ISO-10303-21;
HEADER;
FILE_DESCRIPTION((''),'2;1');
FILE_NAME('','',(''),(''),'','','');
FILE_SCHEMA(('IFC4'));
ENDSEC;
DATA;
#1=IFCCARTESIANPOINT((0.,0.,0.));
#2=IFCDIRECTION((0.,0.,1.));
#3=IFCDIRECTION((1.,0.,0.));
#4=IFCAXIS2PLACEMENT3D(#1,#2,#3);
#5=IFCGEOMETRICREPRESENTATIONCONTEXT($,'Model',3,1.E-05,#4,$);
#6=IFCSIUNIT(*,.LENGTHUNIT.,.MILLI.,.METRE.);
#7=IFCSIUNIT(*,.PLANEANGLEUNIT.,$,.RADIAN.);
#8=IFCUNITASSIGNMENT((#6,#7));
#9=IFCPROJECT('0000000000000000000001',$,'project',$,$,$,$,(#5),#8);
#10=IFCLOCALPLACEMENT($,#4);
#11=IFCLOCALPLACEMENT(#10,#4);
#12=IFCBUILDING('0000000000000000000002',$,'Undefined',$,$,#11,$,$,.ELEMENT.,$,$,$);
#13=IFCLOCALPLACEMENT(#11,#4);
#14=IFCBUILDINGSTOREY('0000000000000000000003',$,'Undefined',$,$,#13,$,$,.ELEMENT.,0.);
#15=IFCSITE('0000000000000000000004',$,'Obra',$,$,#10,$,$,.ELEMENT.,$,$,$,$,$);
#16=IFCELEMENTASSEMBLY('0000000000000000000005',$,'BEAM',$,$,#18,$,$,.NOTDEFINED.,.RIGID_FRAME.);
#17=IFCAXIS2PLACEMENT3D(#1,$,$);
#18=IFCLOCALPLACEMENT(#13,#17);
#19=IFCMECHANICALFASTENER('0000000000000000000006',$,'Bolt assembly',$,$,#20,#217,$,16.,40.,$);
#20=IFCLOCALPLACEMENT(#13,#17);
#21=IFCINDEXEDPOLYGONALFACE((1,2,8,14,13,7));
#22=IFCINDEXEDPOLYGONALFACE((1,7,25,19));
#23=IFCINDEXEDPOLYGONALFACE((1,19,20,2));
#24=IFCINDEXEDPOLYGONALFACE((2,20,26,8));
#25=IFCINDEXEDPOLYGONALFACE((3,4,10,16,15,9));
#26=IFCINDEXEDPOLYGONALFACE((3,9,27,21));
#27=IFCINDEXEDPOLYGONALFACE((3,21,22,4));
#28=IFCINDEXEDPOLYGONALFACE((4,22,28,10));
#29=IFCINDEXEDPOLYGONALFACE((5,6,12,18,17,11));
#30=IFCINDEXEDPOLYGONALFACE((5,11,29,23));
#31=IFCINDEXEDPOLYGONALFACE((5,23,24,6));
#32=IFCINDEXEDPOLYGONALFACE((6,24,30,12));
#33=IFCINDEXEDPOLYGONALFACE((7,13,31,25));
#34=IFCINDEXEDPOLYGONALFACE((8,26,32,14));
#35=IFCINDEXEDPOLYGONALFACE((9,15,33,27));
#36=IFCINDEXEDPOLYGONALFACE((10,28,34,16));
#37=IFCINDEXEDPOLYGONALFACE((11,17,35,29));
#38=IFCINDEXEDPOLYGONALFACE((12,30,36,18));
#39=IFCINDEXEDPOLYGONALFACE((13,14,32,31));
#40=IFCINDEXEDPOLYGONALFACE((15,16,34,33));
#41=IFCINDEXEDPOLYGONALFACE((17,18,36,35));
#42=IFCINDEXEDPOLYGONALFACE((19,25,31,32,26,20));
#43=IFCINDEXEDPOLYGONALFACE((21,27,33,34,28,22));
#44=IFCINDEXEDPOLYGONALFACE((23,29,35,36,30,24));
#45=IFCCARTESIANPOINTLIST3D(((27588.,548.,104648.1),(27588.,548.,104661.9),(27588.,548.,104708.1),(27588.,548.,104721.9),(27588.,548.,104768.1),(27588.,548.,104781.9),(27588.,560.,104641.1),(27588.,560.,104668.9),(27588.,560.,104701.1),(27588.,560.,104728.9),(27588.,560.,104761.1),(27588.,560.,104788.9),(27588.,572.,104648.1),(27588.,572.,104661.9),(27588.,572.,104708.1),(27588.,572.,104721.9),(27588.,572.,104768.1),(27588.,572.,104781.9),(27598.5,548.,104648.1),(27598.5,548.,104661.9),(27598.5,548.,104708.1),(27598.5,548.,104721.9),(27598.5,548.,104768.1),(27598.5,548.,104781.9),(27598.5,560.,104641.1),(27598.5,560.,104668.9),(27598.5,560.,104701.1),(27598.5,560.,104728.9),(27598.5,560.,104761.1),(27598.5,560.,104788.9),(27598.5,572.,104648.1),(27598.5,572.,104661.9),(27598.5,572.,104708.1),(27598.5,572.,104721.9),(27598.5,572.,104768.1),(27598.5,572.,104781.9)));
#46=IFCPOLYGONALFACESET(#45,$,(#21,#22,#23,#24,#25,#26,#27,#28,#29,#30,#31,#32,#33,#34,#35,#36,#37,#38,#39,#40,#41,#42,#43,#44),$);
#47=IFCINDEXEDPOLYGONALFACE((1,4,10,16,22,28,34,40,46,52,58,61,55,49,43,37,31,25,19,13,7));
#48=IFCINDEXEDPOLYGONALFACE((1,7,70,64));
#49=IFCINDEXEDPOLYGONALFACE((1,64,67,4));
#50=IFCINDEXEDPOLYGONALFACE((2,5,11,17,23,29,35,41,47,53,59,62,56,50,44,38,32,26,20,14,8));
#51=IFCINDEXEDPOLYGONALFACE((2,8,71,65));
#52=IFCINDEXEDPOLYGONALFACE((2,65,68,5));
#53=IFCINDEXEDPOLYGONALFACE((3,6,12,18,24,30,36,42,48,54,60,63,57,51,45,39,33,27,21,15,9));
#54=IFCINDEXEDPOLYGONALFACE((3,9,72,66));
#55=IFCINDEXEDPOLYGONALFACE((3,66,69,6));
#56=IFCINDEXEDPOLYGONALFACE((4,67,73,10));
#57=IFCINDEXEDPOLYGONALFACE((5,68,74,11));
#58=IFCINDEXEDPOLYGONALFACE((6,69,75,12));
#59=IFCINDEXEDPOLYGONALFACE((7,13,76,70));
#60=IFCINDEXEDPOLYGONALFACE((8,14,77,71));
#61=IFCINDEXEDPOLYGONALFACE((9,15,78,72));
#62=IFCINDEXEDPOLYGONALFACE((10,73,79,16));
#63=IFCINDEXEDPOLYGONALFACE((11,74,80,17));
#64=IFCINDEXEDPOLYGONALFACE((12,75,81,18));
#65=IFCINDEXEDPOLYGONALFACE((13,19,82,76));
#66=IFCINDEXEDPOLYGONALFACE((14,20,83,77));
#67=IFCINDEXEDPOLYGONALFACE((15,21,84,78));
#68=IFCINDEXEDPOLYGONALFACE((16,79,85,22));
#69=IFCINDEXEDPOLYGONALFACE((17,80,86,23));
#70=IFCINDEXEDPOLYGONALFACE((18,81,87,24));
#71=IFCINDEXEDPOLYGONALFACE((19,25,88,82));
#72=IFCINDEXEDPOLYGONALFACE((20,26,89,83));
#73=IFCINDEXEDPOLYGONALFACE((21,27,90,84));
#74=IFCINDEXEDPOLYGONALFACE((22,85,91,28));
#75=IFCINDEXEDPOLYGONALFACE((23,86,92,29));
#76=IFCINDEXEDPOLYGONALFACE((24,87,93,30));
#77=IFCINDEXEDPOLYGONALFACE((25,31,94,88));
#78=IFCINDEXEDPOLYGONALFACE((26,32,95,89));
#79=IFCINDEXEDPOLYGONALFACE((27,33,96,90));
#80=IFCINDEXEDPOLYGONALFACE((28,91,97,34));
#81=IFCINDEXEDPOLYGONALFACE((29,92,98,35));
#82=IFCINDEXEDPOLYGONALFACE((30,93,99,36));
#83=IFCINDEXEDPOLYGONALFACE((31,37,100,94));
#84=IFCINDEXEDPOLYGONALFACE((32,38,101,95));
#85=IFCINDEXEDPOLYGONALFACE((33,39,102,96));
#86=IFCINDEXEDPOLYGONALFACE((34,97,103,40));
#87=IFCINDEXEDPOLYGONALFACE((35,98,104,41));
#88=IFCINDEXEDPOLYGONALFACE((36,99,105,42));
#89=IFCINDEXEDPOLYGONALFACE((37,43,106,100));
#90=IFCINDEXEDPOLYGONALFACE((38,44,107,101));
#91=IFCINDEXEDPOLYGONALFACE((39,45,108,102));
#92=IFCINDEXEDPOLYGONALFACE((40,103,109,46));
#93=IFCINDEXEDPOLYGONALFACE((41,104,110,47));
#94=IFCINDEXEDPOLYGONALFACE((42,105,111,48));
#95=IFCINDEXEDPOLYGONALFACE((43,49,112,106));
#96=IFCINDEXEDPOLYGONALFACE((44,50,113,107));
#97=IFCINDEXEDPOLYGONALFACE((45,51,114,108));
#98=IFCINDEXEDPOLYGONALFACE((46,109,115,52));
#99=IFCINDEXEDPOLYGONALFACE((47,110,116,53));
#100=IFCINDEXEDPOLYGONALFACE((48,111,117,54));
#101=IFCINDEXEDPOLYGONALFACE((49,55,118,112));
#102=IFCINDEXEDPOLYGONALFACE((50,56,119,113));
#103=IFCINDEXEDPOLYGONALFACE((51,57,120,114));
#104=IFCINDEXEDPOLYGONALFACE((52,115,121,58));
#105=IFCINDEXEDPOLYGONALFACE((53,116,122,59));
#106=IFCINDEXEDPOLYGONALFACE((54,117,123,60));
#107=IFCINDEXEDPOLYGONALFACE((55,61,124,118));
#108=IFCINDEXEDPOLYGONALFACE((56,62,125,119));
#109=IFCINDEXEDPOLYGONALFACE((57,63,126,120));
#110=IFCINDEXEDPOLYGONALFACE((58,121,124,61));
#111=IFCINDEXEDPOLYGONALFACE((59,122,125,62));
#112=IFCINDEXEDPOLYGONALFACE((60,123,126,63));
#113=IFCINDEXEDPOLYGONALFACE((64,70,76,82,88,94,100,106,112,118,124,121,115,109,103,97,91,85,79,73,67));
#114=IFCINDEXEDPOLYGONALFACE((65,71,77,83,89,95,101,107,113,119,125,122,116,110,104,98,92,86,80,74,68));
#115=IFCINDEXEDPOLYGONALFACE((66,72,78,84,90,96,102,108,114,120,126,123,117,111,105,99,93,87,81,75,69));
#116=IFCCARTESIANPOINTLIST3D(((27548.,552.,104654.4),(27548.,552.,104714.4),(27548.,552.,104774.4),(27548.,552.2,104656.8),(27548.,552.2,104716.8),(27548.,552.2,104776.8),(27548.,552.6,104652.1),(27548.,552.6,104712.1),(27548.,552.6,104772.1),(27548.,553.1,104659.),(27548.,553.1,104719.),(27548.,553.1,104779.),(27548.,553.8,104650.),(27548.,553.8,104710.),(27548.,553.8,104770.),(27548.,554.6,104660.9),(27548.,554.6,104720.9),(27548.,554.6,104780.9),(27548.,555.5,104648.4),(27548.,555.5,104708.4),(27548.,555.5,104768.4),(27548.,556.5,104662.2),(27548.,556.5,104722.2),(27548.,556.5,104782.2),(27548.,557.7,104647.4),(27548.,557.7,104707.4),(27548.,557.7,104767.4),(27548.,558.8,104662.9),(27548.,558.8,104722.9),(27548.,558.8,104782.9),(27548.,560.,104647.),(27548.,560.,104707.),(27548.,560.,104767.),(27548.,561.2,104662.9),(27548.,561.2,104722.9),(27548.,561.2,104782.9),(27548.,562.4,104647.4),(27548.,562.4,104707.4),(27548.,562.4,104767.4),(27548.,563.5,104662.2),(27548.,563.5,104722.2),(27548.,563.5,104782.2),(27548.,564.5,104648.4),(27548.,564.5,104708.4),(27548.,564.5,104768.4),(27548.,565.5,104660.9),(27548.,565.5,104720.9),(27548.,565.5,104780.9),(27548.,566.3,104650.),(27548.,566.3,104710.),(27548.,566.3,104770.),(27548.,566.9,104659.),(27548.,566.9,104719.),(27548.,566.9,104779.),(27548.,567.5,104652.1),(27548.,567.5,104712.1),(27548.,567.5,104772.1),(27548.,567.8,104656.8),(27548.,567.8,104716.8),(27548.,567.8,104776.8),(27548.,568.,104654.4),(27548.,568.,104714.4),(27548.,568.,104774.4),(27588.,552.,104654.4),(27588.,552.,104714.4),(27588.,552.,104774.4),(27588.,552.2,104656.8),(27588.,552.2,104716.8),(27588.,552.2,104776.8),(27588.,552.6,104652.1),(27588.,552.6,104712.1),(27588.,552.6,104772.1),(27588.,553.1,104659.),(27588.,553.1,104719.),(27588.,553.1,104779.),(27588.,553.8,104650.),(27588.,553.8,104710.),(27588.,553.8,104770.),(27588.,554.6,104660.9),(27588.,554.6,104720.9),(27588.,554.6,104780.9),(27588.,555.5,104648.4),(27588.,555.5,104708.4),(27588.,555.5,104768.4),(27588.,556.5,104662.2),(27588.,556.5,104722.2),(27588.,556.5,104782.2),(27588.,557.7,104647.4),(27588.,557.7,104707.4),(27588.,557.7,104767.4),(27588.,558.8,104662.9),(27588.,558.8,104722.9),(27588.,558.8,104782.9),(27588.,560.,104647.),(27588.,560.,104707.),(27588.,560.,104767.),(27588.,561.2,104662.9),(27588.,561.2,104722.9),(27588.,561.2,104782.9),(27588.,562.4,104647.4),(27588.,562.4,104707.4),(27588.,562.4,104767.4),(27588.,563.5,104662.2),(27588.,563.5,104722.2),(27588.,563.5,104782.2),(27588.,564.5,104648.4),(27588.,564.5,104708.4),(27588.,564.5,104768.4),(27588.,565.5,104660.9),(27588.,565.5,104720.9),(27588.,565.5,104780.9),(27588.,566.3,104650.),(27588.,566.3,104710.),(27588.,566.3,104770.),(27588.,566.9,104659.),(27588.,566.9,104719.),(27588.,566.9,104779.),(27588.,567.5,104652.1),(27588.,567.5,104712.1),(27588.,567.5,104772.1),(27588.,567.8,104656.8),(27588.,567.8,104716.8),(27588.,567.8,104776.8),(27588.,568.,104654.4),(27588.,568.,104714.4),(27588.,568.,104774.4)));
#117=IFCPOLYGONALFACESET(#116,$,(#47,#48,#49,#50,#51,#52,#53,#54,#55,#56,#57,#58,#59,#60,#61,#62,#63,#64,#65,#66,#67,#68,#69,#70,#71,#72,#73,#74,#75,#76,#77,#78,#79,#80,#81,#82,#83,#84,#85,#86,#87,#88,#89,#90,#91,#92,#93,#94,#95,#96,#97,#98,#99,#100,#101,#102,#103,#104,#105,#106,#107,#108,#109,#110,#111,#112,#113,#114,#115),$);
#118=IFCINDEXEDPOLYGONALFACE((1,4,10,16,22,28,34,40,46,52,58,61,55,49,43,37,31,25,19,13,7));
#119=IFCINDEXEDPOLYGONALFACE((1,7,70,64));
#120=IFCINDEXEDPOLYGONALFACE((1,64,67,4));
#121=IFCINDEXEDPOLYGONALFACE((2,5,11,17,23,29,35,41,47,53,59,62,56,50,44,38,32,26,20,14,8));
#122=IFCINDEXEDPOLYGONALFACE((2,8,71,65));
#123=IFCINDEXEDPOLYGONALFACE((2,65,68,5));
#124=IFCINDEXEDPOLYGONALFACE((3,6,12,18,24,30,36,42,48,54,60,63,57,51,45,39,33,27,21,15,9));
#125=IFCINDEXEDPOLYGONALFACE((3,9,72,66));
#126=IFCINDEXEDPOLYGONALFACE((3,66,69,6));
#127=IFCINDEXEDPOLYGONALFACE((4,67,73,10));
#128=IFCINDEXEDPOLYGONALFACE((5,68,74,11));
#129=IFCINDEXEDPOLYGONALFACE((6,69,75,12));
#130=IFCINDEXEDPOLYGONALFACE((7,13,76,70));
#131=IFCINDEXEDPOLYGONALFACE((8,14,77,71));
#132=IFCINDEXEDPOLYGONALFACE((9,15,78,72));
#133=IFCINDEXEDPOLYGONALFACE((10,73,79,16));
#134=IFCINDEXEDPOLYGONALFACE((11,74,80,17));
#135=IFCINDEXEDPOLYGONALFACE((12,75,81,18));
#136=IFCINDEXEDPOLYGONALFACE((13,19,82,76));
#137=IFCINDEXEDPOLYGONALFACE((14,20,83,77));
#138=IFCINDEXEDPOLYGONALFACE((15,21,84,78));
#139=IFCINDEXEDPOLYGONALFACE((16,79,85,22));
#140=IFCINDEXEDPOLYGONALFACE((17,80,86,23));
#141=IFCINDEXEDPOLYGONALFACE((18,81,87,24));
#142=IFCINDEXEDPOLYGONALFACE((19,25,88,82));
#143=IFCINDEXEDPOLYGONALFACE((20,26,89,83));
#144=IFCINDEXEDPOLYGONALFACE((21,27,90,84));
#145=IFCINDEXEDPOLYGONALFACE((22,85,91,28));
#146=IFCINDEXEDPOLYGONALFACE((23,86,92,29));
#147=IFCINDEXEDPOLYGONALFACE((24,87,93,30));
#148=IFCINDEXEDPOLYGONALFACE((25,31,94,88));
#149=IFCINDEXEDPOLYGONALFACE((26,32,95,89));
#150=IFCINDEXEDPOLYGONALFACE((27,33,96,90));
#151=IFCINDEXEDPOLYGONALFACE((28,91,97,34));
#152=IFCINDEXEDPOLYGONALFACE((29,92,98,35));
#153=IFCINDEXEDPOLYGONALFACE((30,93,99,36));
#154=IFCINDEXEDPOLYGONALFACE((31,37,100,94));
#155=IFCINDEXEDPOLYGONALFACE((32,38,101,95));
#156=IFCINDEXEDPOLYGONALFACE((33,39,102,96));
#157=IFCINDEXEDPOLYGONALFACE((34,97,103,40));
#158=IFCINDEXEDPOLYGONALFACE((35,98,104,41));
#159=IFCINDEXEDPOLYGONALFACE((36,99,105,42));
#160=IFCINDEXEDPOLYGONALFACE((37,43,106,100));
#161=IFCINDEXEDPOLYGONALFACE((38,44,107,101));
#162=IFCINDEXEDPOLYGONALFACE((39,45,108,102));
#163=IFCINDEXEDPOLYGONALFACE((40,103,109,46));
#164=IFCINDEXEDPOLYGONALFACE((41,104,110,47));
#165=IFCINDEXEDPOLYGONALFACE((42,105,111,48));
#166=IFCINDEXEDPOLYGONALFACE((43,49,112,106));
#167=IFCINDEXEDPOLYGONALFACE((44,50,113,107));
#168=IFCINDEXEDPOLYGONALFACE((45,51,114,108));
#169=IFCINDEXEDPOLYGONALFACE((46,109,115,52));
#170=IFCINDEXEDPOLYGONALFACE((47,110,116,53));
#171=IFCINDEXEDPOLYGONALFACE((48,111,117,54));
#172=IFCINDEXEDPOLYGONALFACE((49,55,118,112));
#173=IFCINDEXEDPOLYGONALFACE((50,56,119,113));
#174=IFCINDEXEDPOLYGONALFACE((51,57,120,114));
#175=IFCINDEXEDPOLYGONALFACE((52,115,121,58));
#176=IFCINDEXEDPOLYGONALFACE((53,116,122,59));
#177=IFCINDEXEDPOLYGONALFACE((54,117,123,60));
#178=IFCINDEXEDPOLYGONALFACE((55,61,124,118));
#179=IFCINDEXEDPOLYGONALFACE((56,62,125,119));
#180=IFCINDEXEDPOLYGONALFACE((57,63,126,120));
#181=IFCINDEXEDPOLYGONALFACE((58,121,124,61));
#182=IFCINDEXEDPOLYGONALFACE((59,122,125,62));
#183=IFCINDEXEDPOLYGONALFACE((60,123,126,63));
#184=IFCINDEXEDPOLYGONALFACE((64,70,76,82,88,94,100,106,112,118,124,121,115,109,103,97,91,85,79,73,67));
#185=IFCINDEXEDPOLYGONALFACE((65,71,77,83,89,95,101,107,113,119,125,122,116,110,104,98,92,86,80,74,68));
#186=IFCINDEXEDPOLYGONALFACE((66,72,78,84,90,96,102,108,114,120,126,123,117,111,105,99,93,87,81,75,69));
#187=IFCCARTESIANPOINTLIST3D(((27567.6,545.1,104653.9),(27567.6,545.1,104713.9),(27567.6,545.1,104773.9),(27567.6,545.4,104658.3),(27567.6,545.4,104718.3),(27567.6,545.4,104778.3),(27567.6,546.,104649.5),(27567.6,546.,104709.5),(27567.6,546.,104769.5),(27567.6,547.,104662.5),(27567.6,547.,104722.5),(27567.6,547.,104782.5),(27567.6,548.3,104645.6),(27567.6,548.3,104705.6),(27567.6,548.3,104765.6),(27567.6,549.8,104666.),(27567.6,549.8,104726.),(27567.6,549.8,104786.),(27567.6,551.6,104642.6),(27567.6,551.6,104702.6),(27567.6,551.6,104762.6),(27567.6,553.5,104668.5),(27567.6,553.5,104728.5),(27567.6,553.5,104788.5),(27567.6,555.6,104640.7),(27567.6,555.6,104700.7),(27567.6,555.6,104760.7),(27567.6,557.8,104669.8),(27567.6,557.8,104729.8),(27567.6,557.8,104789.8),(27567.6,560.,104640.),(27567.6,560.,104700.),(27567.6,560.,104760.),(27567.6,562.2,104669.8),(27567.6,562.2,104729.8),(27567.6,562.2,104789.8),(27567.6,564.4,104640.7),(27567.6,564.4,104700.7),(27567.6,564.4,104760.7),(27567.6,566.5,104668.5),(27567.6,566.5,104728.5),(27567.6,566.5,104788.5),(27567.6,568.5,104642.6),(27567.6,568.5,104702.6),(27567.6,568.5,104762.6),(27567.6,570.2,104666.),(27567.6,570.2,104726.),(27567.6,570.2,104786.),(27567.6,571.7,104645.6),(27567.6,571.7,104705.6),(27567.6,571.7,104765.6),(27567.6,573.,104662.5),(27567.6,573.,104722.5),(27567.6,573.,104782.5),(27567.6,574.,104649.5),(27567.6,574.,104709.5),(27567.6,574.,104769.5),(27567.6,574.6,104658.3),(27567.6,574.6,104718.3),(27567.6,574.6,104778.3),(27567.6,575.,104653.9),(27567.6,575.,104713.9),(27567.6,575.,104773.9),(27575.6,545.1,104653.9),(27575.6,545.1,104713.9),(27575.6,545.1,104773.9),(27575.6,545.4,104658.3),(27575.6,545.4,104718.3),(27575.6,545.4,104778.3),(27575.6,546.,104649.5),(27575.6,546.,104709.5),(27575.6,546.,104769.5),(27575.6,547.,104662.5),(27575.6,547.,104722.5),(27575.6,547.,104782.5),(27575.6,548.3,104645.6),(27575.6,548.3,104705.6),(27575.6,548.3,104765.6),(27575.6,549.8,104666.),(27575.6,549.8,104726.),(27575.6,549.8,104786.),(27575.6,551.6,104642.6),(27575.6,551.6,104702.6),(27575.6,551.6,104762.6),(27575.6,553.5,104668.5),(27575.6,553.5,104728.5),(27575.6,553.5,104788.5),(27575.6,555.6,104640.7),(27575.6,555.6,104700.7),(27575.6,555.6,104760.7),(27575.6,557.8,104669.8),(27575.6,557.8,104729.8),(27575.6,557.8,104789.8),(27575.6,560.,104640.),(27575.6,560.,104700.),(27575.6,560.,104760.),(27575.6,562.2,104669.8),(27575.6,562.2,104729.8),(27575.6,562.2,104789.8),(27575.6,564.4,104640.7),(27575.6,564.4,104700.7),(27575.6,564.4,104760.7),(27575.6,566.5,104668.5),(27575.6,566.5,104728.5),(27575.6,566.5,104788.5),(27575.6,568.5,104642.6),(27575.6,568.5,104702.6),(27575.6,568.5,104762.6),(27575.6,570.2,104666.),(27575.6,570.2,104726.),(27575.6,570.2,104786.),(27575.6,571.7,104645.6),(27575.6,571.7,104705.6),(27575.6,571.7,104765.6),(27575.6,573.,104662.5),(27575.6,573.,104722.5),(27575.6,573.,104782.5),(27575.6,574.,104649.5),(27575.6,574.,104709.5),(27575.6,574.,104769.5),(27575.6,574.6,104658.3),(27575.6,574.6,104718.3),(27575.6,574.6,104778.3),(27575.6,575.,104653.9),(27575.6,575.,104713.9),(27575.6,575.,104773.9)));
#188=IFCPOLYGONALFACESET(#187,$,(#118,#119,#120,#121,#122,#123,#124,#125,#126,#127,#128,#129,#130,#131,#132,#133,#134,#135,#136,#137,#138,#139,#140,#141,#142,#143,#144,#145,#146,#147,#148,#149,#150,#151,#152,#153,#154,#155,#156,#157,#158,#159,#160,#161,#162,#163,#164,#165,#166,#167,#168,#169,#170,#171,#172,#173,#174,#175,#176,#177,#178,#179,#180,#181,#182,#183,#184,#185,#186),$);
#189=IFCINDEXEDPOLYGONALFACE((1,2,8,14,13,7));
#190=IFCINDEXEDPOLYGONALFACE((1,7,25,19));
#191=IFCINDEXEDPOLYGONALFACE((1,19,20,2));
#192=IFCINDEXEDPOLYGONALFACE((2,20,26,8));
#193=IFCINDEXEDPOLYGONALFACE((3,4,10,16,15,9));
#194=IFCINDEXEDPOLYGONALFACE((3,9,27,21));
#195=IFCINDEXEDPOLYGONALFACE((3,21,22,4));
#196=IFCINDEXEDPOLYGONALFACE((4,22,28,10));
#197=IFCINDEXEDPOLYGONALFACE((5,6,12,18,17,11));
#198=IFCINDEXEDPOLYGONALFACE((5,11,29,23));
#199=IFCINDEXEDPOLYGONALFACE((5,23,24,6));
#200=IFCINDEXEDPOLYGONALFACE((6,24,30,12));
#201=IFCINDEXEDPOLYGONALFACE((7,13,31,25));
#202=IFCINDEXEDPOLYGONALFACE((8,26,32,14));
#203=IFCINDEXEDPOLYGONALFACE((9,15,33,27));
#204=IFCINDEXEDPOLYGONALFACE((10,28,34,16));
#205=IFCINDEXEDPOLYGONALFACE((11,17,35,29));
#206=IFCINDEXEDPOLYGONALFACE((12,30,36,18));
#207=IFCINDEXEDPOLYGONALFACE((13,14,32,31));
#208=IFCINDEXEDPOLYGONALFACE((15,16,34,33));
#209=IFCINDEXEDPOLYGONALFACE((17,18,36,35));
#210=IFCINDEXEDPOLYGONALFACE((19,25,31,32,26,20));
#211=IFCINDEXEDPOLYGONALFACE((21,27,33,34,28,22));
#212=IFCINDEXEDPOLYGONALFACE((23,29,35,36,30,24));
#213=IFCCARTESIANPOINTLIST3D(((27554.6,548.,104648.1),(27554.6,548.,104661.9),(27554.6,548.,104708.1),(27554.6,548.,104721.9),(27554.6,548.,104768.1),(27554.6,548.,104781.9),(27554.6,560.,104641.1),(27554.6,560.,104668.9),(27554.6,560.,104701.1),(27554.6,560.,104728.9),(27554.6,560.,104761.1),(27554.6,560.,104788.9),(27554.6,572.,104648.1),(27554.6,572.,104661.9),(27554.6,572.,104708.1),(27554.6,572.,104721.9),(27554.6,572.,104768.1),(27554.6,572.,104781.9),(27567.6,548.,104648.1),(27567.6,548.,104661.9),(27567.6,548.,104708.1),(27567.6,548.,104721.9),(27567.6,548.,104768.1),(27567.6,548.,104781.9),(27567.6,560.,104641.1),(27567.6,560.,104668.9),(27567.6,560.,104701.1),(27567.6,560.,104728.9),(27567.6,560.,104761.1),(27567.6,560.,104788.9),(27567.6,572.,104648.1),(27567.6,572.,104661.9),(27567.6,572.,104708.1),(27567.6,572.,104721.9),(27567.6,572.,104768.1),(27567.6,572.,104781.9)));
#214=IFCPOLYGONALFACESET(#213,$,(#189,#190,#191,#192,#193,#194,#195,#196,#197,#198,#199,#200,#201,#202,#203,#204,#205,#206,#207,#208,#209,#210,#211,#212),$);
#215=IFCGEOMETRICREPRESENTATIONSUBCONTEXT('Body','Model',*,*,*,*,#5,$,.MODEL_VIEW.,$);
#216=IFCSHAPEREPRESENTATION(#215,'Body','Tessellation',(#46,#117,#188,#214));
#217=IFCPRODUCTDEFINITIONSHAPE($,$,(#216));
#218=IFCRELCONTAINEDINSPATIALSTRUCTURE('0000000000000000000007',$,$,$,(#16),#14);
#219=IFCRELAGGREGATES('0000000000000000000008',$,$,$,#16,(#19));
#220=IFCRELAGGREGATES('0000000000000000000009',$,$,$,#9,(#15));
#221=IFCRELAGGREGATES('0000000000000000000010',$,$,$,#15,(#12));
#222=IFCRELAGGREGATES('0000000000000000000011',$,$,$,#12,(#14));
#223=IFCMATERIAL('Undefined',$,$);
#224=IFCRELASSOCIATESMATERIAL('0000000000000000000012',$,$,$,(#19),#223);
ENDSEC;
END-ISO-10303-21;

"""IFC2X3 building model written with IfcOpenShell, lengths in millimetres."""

from ifc_helpers import new_model, si_unit, frame, origin_with_axes, origin_2d_with_axis, place, context, subcontext, project, spatial, polyline, circle, outline, extrude, source, transform, mapped, material, element, aggregate, save


model = new_model("IFC2X3")

# Units and contexts
model_context = context("Model", 3, precision=1e-05, world=origin_with_axes())
body_context = subcontext(model_context, "Body", "Model", "MODEL_VIEW")
ifc_project = project(units=[si_unit("LENGTHUNIT", "METRE", prefix="MILLI"), si_unit("PLANEANGLEUNIT", "RADIAN")], contexts=[model_context])

# Site, building, storey
site_placement = place(None, origin_with_axes())
site = spatial("IfcSite", under=ifc_project, at=site_placement, Name="Obra", CompositionType="ELEMENT")
building_placement = place(site_placement, origin_with_axes())
building = spatial("IfcBuilding", under=site, at=building_placement, Name="Undefined", CompositionType="ELEMENT")
storey_placement = place(building_placement, origin_with_axes())
storey = spatial("IfcBuildingStorey", under=building, at=storey_placement, Name="Undefined", CompositionType="ELEMENT", Elevation=0.0)

# Shared definitions
ifc_material_1 = material(Name="Undefined")

# Element assembly, mechanical fastener
assembly_1_placement = place(storey_placement, origin_with_axes())
assembly_1 = element("IfcElementAssembly", 1, at=assembly_1_placement, inside=storey, Name="BEAM", AssemblyPlace="NOTDEFINED", PredefinedType="RIGID_FRAME")
shared_shape_1 = source(origin_with_axes(), body_context, "Body", "SweptSolid", [
    extrude(outline(polyline([(13.9, 0.0), (6.9, 12.0), (-6.9, 12.0), (-13.9, 0.0), (-6.9, -12.0), (6.9, -12.0), (13.9, 0.0)])), frame((0.0, -19.7, 0.0), z_axis=(0.0, 1.0, 0.0), x_axis=(1.0, 0.0, 0.0)), (0.0, 0.0, 1.0), 10.6),
    extrude(circle(Radius=8.0, at=origin_2d_with_axis()), frame((0.0, -9.1, 0.0), z_axis=(0.0, 1.0, 0.0), x_axis=(1.0, 0.0, 0.0)), (0.0, 0.0, 1.0), 40.0),
    extrude(circle(Radius=15.0, at=origin_2d_with_axis()), frame((0.0, 3.3, 0.0), z_axis=(0.0, 1.0, 0.0), x_axis=(1.0, 0.0, 0.0)), (0.0, 0.0, 1.0), 8.0),
    extrude(outline(polyline([(13.9, 0.0), (6.9, 12.0), (-6.9, 12.0), (-13.9, 0.0), (-6.9, -12.0), (6.9, -12.0), (13.9, 0.0)])), frame((0.0, 11.3, 0.0), z_axis=(0.0, 1.0, 0.0), x_axis=(1.0, 0.0, 0.0)), (0.0, 0.0, 1.0), 13.0),
])
mechanical_fastener_1_placement = place(assembly_1_placement, frame((27578.9, 510.0, 104835.0), z_axis=(-0.000002, 1.0, 0.0), x_axis=(0.0, 0.0, -1.0)))
mechanical_fastener_1 = element("IfcMechanicalFastener", 2, at=mechanical_fastener_1_placement, material=ifc_material_1, Name="Bolt assembly", NominalDiameter=16.0, NominalLength=40.0, context=body_context, shape_type="MappedRepresentation", body=[
    mapped(shared_shape_1, transform((60.0, 0.0, 50.0))),
    mapped(shared_shape_1, transform((120.0, 0.0, 50.0))),
    mapped(shared_shape_1, transform((180.0, 0.0, 50.0))),
])
aggregate(assembly_1, [mechanical_fastener_1])

save(model, "model.ifc")
